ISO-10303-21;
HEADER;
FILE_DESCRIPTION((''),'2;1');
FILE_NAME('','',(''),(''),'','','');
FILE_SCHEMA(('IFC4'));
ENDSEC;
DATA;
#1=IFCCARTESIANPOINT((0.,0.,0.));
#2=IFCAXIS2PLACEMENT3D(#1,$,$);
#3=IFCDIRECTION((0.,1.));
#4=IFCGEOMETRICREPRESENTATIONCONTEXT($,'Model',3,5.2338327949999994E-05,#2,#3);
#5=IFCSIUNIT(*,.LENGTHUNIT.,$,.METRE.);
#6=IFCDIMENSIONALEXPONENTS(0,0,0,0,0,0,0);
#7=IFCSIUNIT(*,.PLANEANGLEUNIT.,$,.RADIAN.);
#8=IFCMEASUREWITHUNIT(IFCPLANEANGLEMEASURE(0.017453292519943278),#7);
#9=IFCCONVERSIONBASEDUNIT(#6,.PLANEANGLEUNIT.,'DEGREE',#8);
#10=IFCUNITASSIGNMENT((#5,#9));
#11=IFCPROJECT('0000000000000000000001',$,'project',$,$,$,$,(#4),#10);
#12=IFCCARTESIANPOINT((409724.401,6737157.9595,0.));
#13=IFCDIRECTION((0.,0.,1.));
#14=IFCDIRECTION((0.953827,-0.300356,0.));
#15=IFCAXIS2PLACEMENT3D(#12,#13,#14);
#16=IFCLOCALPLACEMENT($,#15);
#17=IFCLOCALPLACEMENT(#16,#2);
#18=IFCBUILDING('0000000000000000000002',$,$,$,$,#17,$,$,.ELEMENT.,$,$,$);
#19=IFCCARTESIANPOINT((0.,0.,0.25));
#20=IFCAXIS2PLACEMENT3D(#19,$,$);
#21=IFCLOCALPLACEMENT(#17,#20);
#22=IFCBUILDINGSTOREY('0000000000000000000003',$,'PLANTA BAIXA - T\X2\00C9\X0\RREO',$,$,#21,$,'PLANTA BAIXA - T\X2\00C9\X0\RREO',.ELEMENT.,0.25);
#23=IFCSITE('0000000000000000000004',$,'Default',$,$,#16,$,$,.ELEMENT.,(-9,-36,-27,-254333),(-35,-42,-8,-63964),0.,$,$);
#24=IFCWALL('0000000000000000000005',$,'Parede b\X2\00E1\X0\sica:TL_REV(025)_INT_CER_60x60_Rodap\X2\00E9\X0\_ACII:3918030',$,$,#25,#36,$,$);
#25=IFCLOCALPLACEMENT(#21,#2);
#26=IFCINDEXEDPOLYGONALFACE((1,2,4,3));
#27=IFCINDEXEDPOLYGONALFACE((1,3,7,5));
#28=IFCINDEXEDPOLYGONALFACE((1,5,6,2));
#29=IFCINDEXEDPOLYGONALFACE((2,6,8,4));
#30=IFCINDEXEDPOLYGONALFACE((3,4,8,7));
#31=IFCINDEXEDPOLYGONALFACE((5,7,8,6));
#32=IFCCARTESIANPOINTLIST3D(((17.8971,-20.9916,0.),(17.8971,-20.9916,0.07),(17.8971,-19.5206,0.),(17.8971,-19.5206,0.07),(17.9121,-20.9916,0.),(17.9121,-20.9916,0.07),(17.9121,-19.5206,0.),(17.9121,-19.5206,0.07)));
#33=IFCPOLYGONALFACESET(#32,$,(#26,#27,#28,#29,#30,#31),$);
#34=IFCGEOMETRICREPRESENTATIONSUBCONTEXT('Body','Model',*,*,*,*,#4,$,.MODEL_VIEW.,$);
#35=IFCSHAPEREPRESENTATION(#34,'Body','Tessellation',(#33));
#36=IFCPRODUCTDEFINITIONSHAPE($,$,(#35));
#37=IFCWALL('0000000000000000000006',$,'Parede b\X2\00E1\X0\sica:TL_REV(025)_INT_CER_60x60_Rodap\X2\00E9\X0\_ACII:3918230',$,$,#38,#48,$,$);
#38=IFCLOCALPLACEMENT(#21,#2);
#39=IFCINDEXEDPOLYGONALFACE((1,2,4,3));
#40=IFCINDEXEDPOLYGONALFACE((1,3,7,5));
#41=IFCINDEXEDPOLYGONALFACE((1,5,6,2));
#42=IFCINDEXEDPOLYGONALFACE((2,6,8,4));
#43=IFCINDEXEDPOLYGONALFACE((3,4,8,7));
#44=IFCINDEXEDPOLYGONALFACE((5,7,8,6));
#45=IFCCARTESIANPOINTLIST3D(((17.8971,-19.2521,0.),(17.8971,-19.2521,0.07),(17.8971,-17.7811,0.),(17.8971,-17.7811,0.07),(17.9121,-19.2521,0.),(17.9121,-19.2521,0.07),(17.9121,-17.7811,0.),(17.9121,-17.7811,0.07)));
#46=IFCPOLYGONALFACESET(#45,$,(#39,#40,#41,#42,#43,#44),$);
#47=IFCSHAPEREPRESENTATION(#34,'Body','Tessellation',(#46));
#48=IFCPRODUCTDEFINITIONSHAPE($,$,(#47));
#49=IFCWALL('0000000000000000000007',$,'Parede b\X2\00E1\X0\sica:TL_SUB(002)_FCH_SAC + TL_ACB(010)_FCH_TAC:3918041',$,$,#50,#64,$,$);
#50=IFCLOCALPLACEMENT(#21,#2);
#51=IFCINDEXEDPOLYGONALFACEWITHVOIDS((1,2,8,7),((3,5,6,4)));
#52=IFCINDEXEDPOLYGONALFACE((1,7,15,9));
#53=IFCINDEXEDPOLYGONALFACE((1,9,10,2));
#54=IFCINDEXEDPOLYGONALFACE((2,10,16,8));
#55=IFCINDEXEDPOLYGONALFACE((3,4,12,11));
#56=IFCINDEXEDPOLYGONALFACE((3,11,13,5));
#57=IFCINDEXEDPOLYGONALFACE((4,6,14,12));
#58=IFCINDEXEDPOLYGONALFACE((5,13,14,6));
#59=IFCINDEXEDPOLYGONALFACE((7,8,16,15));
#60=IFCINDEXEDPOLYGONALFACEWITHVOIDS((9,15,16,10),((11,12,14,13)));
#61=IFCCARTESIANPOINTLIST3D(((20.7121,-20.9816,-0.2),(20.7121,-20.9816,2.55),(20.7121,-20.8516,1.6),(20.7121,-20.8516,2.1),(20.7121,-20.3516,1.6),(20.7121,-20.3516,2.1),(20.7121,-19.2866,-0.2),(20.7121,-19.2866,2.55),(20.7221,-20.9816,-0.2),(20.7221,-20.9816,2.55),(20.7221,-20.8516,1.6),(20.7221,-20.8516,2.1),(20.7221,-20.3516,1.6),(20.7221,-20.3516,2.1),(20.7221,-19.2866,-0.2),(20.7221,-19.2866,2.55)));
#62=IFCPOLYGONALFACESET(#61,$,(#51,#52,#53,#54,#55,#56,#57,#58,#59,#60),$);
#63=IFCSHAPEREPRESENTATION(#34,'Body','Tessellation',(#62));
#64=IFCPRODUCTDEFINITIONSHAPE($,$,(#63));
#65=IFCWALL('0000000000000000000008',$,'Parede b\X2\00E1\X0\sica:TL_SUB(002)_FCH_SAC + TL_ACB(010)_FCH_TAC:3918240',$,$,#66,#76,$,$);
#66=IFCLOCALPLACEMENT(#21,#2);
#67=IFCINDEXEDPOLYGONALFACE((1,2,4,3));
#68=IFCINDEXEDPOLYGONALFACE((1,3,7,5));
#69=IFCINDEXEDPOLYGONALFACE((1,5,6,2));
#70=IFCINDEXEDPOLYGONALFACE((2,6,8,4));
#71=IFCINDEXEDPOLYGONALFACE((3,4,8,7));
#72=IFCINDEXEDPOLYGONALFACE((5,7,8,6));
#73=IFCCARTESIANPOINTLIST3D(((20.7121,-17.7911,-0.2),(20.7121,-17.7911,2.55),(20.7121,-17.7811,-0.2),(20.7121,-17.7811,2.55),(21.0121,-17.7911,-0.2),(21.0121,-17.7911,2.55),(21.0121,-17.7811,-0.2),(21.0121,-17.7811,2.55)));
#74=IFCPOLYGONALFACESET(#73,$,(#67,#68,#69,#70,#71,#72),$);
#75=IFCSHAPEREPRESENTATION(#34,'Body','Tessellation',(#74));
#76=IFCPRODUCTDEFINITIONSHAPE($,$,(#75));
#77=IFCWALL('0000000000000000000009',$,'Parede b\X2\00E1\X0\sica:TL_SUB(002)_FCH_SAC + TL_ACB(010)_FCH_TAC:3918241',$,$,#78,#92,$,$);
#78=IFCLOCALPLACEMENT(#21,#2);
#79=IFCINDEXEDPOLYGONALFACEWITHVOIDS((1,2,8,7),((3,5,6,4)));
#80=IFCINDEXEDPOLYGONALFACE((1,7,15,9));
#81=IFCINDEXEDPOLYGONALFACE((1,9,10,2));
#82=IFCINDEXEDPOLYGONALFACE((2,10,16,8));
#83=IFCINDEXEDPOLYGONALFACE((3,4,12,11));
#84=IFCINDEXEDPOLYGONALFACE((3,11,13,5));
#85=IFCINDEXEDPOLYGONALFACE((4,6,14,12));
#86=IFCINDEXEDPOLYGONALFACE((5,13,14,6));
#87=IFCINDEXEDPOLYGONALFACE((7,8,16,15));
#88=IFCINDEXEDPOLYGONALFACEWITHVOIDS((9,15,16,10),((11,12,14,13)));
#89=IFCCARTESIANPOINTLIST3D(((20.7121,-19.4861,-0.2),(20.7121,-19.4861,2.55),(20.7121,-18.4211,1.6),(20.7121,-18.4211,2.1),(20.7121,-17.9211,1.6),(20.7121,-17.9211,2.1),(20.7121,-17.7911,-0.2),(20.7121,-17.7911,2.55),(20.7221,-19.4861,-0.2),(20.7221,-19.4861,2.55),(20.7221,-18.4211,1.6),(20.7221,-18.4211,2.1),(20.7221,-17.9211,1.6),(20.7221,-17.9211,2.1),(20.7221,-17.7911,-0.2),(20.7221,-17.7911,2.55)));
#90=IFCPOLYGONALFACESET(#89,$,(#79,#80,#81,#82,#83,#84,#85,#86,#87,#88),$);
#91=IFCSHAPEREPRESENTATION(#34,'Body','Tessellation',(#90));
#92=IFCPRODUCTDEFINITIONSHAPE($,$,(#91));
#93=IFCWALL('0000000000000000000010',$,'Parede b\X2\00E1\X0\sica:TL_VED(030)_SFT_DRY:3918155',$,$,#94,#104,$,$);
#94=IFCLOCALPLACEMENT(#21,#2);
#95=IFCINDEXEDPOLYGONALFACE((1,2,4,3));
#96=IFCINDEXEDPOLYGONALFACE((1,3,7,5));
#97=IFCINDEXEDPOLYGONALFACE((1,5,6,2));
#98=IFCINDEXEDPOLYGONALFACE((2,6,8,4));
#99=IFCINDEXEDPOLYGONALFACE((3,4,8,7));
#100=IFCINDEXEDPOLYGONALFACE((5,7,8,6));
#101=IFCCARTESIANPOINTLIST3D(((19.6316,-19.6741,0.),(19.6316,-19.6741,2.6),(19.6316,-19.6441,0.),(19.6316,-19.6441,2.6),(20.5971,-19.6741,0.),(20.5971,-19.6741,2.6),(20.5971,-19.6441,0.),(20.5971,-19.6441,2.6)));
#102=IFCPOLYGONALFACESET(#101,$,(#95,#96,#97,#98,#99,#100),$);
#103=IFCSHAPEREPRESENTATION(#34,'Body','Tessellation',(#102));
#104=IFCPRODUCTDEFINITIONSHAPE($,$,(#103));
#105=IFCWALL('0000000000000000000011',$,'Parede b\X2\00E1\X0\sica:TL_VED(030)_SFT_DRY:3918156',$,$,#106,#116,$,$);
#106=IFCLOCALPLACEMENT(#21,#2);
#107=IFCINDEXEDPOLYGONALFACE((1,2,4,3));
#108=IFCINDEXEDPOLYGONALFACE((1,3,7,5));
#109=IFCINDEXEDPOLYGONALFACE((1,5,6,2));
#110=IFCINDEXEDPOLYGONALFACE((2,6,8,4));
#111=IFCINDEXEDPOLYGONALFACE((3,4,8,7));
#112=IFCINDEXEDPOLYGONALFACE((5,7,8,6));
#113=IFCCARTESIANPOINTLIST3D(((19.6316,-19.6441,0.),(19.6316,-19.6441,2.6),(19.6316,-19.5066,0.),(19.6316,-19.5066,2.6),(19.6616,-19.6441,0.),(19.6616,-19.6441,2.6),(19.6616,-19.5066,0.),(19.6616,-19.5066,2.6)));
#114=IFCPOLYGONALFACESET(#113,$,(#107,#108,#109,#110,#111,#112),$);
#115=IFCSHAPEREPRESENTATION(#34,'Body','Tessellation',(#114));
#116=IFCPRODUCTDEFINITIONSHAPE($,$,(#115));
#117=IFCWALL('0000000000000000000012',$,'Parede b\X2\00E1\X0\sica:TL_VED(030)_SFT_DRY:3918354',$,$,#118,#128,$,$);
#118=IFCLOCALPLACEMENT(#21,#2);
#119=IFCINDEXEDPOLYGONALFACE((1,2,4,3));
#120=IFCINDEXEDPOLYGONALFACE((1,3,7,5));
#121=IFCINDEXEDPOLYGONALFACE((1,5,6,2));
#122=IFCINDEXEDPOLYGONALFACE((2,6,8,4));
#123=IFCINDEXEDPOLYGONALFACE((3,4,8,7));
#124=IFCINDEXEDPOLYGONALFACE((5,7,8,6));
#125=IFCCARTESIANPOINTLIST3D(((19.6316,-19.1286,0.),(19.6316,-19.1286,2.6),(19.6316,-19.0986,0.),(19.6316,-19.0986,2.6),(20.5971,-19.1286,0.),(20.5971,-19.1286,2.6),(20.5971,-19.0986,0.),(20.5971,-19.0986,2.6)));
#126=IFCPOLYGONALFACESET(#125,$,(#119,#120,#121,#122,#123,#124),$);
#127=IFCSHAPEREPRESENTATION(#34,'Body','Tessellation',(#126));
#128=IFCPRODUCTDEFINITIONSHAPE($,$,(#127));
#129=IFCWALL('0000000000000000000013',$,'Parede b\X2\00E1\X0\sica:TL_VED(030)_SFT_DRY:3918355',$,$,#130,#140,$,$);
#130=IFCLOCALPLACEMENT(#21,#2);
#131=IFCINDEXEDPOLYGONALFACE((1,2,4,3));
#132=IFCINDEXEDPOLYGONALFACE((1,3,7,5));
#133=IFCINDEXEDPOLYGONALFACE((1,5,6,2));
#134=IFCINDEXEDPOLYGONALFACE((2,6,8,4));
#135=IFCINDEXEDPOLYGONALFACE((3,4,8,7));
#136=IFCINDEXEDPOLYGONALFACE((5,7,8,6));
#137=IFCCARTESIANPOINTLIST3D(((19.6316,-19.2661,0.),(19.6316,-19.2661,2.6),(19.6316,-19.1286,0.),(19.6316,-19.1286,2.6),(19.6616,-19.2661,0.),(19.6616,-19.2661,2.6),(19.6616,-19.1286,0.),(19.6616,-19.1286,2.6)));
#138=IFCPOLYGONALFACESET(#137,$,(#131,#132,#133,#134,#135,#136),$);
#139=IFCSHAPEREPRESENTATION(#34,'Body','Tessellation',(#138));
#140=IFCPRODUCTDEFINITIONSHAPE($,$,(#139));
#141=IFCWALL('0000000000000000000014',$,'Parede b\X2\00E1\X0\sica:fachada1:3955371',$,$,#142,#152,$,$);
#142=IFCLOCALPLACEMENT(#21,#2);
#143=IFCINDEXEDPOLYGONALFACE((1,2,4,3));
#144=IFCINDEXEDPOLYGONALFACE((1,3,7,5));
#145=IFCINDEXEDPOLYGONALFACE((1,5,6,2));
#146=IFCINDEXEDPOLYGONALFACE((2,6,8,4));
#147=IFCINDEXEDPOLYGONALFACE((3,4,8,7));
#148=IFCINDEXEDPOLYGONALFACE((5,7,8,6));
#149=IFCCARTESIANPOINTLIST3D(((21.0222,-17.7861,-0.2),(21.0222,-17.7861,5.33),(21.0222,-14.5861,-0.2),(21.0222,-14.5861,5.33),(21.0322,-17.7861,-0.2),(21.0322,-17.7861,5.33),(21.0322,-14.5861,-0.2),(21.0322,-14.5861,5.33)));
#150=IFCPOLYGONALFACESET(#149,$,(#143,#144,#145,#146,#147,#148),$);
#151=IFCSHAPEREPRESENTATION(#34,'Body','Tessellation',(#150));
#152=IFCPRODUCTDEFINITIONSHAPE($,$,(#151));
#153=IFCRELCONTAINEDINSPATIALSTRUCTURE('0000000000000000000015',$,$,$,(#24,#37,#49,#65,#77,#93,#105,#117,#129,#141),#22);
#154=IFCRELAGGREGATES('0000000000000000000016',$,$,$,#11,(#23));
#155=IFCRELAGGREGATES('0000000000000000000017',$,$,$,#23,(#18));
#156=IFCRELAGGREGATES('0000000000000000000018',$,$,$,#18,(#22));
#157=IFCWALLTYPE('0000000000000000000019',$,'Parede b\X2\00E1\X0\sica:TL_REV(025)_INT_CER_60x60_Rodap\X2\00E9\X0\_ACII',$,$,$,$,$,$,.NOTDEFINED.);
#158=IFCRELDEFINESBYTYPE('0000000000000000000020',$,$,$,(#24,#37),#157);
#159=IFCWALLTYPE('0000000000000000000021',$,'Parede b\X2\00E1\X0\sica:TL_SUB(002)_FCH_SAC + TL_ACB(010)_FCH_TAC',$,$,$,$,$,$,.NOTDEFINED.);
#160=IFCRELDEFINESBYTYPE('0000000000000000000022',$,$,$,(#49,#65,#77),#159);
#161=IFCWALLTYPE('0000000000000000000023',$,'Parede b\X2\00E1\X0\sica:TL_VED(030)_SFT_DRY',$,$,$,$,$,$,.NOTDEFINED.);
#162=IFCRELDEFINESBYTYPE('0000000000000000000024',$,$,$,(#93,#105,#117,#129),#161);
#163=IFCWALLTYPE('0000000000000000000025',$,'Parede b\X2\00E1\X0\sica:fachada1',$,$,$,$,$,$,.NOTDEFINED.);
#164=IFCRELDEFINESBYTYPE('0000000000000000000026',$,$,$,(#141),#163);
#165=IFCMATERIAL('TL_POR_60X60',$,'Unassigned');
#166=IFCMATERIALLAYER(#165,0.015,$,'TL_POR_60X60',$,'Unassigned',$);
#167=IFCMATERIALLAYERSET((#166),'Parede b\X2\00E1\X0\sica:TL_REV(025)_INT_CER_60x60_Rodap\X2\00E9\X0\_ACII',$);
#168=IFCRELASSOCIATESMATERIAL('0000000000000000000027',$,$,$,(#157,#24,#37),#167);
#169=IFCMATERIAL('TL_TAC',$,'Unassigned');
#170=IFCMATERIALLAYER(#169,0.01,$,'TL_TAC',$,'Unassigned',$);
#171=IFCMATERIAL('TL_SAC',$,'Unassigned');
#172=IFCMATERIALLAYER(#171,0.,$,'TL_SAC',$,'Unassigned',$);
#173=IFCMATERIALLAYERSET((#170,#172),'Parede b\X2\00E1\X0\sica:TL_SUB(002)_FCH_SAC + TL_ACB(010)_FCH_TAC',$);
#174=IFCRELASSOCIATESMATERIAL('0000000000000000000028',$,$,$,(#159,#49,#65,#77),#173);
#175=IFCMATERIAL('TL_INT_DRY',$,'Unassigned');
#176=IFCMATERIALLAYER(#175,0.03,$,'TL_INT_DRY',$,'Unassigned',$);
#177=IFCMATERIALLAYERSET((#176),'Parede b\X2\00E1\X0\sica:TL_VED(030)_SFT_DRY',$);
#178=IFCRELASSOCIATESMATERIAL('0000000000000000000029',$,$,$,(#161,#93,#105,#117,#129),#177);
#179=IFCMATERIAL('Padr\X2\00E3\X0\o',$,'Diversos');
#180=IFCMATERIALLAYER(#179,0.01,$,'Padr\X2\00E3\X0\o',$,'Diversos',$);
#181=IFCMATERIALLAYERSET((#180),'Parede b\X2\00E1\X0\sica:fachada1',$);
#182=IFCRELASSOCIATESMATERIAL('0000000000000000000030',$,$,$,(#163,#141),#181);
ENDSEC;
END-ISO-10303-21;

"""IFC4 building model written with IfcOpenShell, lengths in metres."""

from ifc_helpers import new_model, entity, si_unit, converted_unit, direction, frame, frame_2d, origin, place, context, subcontext, project, spatial, rectangle, extrude, material, layer, layer_set, layer_usage, type_object, element, save


model = new_model("IFC4")

# Units and contexts
model_context = context("Model", 3, precision=5.2338327949999994e-05, world=origin(), true_north=direction((0.0, 1.0)))
body_context = subcontext(model_context, "Body", "Model", "MODEL_VIEW")
ifc_project = project(units=[si_unit("LENGTHUNIT", "METRE"), converted_unit("PLANEANGLEUNIT", "DEGREE", entity("IfcPlaneAngleMeasure", 0.017453292519943278), si_unit("PLANEANGLEUNIT", "RADIAN"), dimensions=[0, 0, 0, 0, 0, 0, 0])], contexts=[model_context])

# Site, building, storey
site_placement = place(None, frame((409724.401, 6737157.9595, 0.0), z_axis=(0.0, 0.0, 1.0), x_axis=(0.953827, -0.300356, 0.0)))
site = spatial("IfcSite", under=ifc_project, at=site_placement, Name="Default", CompositionType="ELEMENT", RefLatitude=(-9, -36, -27, -254333), RefLongitude=(-35, -42, -8, -63964), RefElevation=0.0)
building_placement = place(site_placement, origin())
building = spatial("IfcBuilding", under=site, at=building_placement, CompositionType="ELEMENT")
storey_placement = place(building_placement, frame((0.0, 0.0, 0.25)))
storey = spatial("IfcBuildingStorey", under=building, at=storey_placement, Name="PLANTA BAIXA - TÉRREO", LongName="PLANTA BAIXA - TÉRREO", CompositionType="ELEMENT", Elevation=0.25)

# Shared definitions
ifc_material_1 = material(Name="TL_SAC", Category="Unassigned")

# Shared definitions
ifc_material_2 = material(Name="TL_POR_60X60", Category="Unassigned")

# Walls
ifc_layer_1 = layer(ifc_material_2, 0.015, Name="TL_POR_60X60", Category="Unassigned")
ifc_layer_set_1 = layer_set([ifc_layer_1], Name="Parede básica:TL_REV(025)_INT_CER_60x60_Rodapé_ACII")
ifc_layer_usage_1 = layer_usage(ifc_layer_set_1, "AXIS2", "POSITIVE", -0.0075)
wall_type_1 = type_object("IfcWallType", Name="Parede básica:TL_REV(025)_INT_CER_60x60_Rodapé_ACII", PredefinedType="NOTDEFINED", material=ifc_layer_set_1)
wall_1_placement = place(storey_placement, frame((17.9046, -19.5206, 0.0), z_axis=(0.0, 0.0, 1.0), x_axis=(0.0, -1.0, 0.0)))
element("IfcWall", 1, at=wall_1_placement, inside=storey, type_object=wall_type_1, material=ifc_layer_usage_1, Name="Parede básica:TL_REV(025)_INT_CER_60x60_Rodapé_ACII:3918030", context=body_context, shape_type="SweptSolid", body=[
    extrude(rectangle(XDim=1.471, YDim=0.015, at=frame_2d((0.7355, 0.0), x_axis=(-1.0, 0.0))), origin(), (0.0, 0.0, 1.0), 0.07),
])
ifc_layer_usage_2 = layer_usage(ifc_layer_set_1, "AXIS2", "NEGATIVE", 0.0075)
wall_2_placement = place(storey_placement, frame((17.9046, -19.2521, 0.0), z_axis=(0.0, 0.0, 1.0), x_axis=(0.0, 1.0, 0.0)))
element("IfcWall", 2, at=wall_2_placement, inside=storey, type_object=wall_type_1, material=ifc_layer_usage_2, Name="Parede básica:TL_REV(025)_INT_CER_60x60_Rodapé_ACII:3918230", context=body_context, shape_type="SweptSolid", body=[
    extrude(rectangle(XDim=1.471, YDim=0.015, at=frame_2d((0.7355, 0.0), x_axis=(-1.0, 0.0))), origin(), (0.0, 0.0, 1.0), 0.07),
])

# Wall, opening
ifc_material_3 = material(Name="TL_TAC", Category="Unassigned")
ifc_layer_2 = layer(ifc_material_3, 0.01, Name="TL_TAC", Category="Unassigned")
ifc_layer_3 = layer(ifc_material_1, 0.0, Name="TL_SAC", Category="Unassigned")
ifc_layer_set_2 = layer_set([ifc_layer_2, ifc_layer_3], Name="Parede básica:TL_SUB(002)_FCH_SAC + TL_ACB(010)_FCH_TAC")
ifc_layer_usage_3 = layer_usage(ifc_layer_set_2, "AXIS2", "NEGATIVE", 0.005)
wall_type_2 = type_object("IfcWallType", Name="Parede básica:TL_SUB(002)_FCH_SAC + TL_ACB(010)_FCH_TAC", PredefinedType="NOTDEFINED", material=ifc_layer_set_2)
wall_3_placement = place(storey_placement, frame((20.7171, -20.9816, -0.2), z_axis=(0.0, 0.0, 1.0), x_axis=(0.0, 1.0, 0.0)))
wall_3 = element("IfcWall", 3, at=wall_3_placement, inside=storey, type_object=wall_type_2, material=ifc_layer_usage_3, Name="Parede básica:TL_SUB(002)_FCH_SAC + TL_ACB(010)_FCH_TAC:3918041", context=body_context, shape_type="SweptSolid", body=[
    extrude(rectangle(XDim=1.695, YDim=0.01, at=frame_2d((0.8475, 0.0), x_axis=(-1.0, 0.0))), origin(), (0.0, 0.0, 1.0), 2.75),
])
opening_1_placement = place(wall_3_placement, frame((20.9816, 20.7171, 1.8)))
element("IfcOpeningElement", 4, at=opening_1_placement, cuts=wall_3, PredefinedType="OPENING", context=body_context, shape_type="SweptSolid", body=[
    extrude(rectangle(XDim=0.5, YDim=0.5, at=frame_2d((0.0, 0.0), x_axis=(1.0, 0.0))), frame((-20.6016, -22.2361, 0.25), z_axis=(0.0, 1.0, 0.0), x_axis=(0.0, 0.0, 1.0)), (0.0, 0.0, 1.0), 3.048),
])

# Wall
ifc_layer_usage_4 = layer_usage(ifc_layer_set_2, "AXIS2", "POSITIVE", -0.005)
wall_4_placement = place(storey_placement, frame((21.0121, -17.7861, -0.2), z_axis=(0.0, 0.0, 1.0), x_axis=(-1.0, 0.0, 0.0)))
element("IfcWall", 5, at=wall_4_placement, inside=storey, type_object=wall_type_2, material=ifc_layer_usage_4, Name="Parede básica:TL_SUB(002)_FCH_SAC + TL_ACB(010)_FCH_TAC:3918240", context=body_context, shape_type="SweptSolid", body=[
    extrude(rectangle(XDim=0.3, YDim=0.01, at=frame_2d((0.15, 0.0), x_axis=(-1.0, 0.0))), origin(), (0.0, 0.0, 1.0), 2.75),
])

# Wall, opening
ifc_layer_usage_5 = layer_usage(ifc_layer_set_2, "AXIS2", "POSITIVE", -0.005)
wall_5_placement = place(storey_placement, frame((20.7171, -17.7911, -0.2), z_axis=(0.0, 0.0, 1.0), x_axis=(0.0, -1.0, 0.0)))
wall_5 = element("IfcWall", 6, at=wall_5_placement, inside=storey, type_object=wall_type_2, material=ifc_layer_usage_5, Name="Parede básica:TL_SUB(002)_FCH_SAC + TL_ACB(010)_FCH_TAC:3918241", context=body_context, shape_type="SweptSolid", body=[
    extrude(rectangle(XDim=1.695, YDim=0.01, at=frame_2d((0.8475, 0.0), x_axis=(-1.0, 0.0))), origin(), (0.0, 0.0, 1.0), 2.75),
])
opening_2_placement = place(wall_5_placement, frame((-17.7911, -20.7171, 1.8)))
element("IfcOpeningElement", 7, at=opening_2_placement, cuts=wall_5, PredefinedType="OPENING", context=body_context, shape_type="SweptSolid", body=[
    extrude(rectangle(XDim=0.5, YDim=0.5, at=frame_2d((0.0, 0.0), x_axis=(1.0, 0.0))), frame((18.1711, 19.1881, 0.25), z_axis=(0.0, 1.0, 0.0), x_axis=(0.0, 0.0, 1.0)), (0.0, 0.0, 1.0), 3.048),
])

# Walls
ifc_material_4 = material(Name="TL_INT_DRY", Category="Unassigned")
ifc_layer_4 = layer(ifc_material_4, 0.03, Name="TL_INT_DRY", Category="Unassigned")
ifc_layer_set_3 = layer_set([ifc_layer_4], Name="Parede básica:TL_VED(030)_SFT_DRY")
ifc_layer_usage_6 = layer_usage(ifc_layer_set_3, "AXIS2", "NEGATIVE", 0.015)
wall_type_3 = type_object("IfcWallType", Name="Parede básica:TL_VED(030)_SFT_DRY", PredefinedType="NOTDEFINED", material=ifc_layer_set_3)
wall_6_placement = place(storey_placement, frame((20.5971, -19.6591, 0.0), z_axis=(0.0, 0.0, 1.0), x_axis=(-1.0, 0.0, 0.0)))
element("IfcWall", 8, at=wall_6_placement, inside=storey, type_object=wall_type_3, material=ifc_layer_usage_6, Name="Parede básica:TL_VED(030)_SFT_DRY:3918155", context=body_context, shape_type="SweptSolid", body=[
    extrude(rectangle(XDim=0.9655, YDim=0.03, at=frame_2d((0.4828, 0.0), x_axis=(-1.0, 0.0))), origin(), (0.0, 0.0, 1.0), 2.6),
])
ifc_layer_usage_7 = layer_usage(ifc_layer_set_3, "AXIS2", "NEGATIVE", 0.015)
wall_7_placement = place(storey_placement, frame((19.6466, -19.6441, 0.0), z_axis=(0.0, 0.0, 1.0), x_axis=(0.0, 1.0, 0.0)))
element("IfcWall", 9, at=wall_7_placement, inside=storey, type_object=wall_type_3, material=ifc_layer_usage_7, Name="Parede básica:TL_VED(030)_SFT_DRY:3918156", context=body_context, shape_type="SweptSolid", body=[
    extrude(rectangle(XDim=0.1375, YDim=0.03, at=frame_2d((0.0688, 0.0), x_axis=(-1.0, 0.0))), origin(), (0.0, 0.0, 1.0), 2.6),
])
ifc_layer_usage_8 = layer_usage(ifc_layer_set_3, "AXIS2", "POSITIVE", -0.015)
wall_8_placement = place(storey_placement, frame((20.5971, -19.1136, 0.0), z_axis=(0.0, 0.0, 1.0), x_axis=(-1.0, 0.0, 0.0)))
element("IfcWall", 10, at=wall_8_placement, inside=storey, type_object=wall_type_3, material=ifc_layer_usage_8, Name="Parede básica:TL_VED(030)_SFT_DRY:3918354", context=body_context, shape_type="SweptSolid", body=[
    extrude(rectangle(XDim=0.9655, YDim=0.03, at=frame_2d((0.4828, 0.0), x_axis=(-1.0, 0.0))), origin(), (0.0, 0.0, 1.0), 2.6),
])
ifc_layer_usage_9 = layer_usage(ifc_layer_set_3, "AXIS2", "POSITIVE", -0.015)
wall_9_placement = place(storey_placement, frame((19.6466, -19.1286, 0.0), z_axis=(0.0, 0.0, 1.0), x_axis=(0.0, -1.0, 0.0)))
element("IfcWall", 11, at=wall_9_placement, inside=storey, type_object=wall_type_3, material=ifc_layer_usage_9, Name="Parede básica:TL_VED(030)_SFT_DRY:3918355", context=body_context, shape_type="SweptSolid", body=[
    extrude(rectangle(XDim=0.1375, YDim=0.03, at=frame_2d((0.0688, 0.0), x_axis=(-1.0, 0.0))), origin(), (0.0, 0.0, 1.0), 2.6),
])
ifc_material_5 = material(Name="Padrão", Category="Diversos")
ifc_layer_5 = layer(ifc_material_5, 0.01, Name="Padrão", Category="Diversos")
ifc_layer_set_4 = layer_set([ifc_layer_5], Name="Parede básica:fachada1")
ifc_layer_usage_10 = layer_usage(ifc_layer_set_4, "AXIS2", "NEGATIVE", 0.005)
wall_type_4 = type_object("IfcWallType", Name="Parede básica:fachada1", PredefinedType="NOTDEFINED", material=ifc_layer_set_4)
wall_10_placement = place(storey_placement, frame((21.0272, -17.7861, -0.2), z_axis=(0.0, 0.0, 1.0), x_axis=(0.0, 1.0, 0.0)))
element("IfcWall", 12, at=wall_10_placement, inside=storey, type_object=wall_type_4, material=ifc_layer_usage_10, Name="Parede básica:fachada1:3955371", context=body_context, shape_type="SweptSolid", body=[
    extrude(rectangle(XDim=3.2, YDim=0.01, at=frame_2d((1.6, 0.0), x_axis=(-1.0, 0.0))), origin(), (0.0, 0.0, 1.0), 5.53),
])

save(model, "model.ifc")
